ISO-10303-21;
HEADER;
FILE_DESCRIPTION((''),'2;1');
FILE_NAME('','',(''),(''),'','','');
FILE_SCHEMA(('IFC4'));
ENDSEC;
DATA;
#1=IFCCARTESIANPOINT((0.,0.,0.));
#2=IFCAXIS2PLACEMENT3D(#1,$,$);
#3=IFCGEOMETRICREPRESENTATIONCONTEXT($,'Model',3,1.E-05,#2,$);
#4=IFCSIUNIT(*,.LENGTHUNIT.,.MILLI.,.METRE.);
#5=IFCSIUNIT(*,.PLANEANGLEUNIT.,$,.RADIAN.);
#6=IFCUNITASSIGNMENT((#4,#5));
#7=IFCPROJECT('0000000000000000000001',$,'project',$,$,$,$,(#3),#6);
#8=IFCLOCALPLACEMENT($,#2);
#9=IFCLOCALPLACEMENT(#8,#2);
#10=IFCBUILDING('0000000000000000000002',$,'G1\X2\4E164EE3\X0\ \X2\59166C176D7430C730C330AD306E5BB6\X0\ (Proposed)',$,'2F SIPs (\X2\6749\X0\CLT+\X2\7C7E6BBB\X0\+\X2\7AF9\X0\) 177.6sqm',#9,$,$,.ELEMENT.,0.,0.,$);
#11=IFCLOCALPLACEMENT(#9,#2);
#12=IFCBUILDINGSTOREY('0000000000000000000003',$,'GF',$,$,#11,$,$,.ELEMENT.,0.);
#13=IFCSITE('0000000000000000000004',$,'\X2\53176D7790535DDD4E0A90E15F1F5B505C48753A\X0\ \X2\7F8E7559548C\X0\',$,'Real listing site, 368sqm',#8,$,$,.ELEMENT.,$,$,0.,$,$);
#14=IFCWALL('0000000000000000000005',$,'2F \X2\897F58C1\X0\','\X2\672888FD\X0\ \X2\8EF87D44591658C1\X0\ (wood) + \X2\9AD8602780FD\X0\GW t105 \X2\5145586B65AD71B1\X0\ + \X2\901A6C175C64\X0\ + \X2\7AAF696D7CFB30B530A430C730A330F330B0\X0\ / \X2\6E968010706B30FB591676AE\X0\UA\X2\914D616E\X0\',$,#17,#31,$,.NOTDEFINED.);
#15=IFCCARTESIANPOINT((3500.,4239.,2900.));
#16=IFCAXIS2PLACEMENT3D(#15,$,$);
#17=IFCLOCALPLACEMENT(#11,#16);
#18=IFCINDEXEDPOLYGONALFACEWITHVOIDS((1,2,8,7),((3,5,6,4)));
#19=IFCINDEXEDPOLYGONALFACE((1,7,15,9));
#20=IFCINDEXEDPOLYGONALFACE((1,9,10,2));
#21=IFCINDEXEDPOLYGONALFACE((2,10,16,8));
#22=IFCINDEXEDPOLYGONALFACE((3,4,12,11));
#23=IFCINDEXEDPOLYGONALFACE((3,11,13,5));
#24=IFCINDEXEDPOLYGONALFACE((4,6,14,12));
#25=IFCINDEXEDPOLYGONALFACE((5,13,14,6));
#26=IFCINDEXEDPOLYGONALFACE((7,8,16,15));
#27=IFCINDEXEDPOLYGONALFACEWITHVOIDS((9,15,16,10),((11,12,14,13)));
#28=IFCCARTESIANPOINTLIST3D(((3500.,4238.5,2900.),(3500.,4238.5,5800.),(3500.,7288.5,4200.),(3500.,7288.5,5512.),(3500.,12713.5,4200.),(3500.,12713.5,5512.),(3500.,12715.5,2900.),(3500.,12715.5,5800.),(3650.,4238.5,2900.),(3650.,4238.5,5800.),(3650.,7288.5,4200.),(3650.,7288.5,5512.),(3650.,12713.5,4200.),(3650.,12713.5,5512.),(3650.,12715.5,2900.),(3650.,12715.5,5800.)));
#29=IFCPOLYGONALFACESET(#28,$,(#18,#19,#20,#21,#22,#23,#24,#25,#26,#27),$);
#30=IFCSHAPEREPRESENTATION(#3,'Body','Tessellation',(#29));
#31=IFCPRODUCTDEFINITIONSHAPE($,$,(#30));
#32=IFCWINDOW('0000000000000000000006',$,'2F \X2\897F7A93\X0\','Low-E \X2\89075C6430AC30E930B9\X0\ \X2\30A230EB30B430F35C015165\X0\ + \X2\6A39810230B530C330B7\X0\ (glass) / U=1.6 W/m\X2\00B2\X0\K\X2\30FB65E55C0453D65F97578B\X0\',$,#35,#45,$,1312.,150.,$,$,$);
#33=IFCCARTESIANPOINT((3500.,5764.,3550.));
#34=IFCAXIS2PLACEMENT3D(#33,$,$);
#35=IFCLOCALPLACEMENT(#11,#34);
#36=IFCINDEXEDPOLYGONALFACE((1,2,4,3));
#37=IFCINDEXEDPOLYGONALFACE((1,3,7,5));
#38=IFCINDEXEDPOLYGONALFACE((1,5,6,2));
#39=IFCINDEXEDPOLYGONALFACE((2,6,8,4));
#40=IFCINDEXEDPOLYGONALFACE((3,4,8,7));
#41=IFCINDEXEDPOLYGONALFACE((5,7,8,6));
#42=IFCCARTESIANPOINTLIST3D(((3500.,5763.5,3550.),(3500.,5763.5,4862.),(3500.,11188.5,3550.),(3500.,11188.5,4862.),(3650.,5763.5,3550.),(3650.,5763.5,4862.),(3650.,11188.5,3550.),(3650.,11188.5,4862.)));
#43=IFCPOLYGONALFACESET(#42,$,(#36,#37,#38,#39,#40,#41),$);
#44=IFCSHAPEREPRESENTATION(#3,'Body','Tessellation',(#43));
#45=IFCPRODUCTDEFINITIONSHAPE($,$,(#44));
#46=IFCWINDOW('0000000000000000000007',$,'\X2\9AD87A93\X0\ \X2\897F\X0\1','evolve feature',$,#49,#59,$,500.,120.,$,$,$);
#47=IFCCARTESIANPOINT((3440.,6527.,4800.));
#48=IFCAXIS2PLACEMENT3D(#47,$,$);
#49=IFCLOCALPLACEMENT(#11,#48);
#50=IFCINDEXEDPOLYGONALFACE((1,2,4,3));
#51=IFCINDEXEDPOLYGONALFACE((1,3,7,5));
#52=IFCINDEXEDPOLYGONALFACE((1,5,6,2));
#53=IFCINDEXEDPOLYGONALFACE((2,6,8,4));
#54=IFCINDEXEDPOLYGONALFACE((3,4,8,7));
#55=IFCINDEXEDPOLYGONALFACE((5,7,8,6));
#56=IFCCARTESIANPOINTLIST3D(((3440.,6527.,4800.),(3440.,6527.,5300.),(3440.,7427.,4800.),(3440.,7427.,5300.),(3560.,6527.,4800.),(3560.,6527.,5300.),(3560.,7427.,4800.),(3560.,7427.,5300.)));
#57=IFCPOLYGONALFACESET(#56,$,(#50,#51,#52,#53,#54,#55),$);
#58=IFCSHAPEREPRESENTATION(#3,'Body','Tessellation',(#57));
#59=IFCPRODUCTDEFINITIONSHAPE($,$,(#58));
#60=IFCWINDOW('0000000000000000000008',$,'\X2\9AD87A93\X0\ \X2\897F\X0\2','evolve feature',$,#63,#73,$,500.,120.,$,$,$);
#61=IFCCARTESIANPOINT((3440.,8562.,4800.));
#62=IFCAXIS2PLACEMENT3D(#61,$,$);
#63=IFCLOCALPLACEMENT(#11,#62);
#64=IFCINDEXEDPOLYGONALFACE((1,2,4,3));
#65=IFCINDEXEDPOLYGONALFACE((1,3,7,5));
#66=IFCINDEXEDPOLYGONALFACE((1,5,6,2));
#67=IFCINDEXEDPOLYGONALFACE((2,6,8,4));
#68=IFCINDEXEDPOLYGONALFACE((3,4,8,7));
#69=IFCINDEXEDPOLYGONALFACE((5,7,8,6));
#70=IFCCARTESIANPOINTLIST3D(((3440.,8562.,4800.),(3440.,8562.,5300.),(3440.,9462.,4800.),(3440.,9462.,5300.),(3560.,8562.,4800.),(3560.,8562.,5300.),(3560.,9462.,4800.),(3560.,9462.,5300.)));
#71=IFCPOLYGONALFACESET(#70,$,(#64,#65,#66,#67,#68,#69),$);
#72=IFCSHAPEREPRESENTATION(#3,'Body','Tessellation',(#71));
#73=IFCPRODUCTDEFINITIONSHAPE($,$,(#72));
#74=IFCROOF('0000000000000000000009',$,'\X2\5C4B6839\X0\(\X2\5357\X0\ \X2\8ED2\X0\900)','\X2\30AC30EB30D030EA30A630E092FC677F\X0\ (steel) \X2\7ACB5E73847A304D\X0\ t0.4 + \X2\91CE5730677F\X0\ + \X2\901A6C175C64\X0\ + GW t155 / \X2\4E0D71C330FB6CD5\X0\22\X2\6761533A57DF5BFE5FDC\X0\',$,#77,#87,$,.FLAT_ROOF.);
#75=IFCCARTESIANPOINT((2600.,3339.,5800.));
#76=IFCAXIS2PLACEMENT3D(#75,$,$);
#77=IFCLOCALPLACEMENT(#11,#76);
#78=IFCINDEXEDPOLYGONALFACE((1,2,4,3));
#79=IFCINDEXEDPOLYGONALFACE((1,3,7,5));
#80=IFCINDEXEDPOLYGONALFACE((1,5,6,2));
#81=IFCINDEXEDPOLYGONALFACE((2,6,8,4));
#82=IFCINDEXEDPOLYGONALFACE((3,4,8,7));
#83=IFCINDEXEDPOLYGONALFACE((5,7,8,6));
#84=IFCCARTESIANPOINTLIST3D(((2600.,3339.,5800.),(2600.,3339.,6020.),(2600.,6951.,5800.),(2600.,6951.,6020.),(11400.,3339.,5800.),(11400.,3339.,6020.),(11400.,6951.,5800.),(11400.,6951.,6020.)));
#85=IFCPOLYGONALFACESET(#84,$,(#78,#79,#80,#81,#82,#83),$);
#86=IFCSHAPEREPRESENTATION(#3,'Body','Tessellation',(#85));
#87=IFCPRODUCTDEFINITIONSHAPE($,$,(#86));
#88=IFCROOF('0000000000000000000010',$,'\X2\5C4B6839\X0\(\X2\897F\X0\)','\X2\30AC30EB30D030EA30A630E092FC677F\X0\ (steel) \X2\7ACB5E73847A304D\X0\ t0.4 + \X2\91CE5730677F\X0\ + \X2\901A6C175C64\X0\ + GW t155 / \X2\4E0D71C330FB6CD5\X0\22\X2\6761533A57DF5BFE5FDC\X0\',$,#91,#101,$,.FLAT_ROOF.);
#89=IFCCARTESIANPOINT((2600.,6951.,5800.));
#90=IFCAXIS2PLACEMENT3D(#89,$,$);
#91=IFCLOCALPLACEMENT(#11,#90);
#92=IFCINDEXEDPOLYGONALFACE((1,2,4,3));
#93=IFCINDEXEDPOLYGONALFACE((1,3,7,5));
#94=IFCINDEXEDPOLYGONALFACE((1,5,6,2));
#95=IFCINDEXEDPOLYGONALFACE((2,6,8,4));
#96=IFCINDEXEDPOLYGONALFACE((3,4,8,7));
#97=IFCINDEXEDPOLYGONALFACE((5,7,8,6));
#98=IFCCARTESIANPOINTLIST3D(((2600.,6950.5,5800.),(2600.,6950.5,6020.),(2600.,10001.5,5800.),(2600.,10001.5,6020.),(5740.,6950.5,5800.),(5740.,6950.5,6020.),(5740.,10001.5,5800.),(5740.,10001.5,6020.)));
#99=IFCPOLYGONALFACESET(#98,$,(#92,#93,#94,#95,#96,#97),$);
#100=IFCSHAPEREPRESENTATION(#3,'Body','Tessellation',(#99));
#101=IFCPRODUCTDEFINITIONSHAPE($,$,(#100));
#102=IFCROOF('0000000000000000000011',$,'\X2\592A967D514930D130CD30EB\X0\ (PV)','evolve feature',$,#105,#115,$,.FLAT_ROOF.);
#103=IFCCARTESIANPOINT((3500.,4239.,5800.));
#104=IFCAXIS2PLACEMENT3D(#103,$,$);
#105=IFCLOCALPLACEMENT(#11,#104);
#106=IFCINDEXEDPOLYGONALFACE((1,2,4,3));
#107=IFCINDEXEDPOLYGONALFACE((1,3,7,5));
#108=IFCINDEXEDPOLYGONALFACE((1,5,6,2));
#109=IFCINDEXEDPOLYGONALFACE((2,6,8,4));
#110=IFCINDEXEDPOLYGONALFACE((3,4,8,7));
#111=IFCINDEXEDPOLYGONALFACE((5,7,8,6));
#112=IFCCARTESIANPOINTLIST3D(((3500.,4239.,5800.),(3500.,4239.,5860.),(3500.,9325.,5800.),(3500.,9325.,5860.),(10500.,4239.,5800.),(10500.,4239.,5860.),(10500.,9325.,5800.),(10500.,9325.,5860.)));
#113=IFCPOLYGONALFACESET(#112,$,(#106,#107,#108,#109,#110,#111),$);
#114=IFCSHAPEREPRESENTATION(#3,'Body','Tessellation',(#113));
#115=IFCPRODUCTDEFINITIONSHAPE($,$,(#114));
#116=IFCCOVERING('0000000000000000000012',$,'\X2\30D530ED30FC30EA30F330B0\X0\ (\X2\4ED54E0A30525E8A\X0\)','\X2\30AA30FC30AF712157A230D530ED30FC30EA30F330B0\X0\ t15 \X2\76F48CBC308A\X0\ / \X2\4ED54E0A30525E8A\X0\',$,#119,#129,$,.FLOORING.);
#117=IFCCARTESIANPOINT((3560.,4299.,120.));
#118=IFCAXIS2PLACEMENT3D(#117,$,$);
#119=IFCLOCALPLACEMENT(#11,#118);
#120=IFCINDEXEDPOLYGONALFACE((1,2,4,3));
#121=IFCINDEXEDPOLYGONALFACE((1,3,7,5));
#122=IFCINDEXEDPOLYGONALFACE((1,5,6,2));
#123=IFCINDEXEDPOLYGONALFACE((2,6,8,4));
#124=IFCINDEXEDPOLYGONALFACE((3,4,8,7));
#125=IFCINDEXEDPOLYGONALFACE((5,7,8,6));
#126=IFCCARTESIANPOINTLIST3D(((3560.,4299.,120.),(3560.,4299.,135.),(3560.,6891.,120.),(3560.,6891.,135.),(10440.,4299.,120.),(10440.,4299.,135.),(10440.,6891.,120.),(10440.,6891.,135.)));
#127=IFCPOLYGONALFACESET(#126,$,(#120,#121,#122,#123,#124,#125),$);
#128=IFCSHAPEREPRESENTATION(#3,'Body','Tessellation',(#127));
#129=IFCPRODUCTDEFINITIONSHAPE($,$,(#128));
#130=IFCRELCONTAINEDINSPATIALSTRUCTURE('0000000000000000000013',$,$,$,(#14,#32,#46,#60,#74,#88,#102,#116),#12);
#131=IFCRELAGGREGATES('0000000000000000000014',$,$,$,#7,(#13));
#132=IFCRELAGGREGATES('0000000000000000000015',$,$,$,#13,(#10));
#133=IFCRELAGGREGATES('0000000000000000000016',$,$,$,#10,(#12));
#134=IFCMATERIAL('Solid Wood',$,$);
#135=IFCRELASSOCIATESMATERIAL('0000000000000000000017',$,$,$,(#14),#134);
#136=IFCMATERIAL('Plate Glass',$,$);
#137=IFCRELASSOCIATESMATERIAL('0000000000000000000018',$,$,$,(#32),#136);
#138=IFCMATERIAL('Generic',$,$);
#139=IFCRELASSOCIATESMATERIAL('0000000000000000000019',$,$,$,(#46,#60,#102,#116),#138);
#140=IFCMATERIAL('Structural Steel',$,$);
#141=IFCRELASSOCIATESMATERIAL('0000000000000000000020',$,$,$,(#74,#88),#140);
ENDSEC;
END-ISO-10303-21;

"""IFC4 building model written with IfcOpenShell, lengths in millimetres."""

from ifc_helpers import new_model, si_unit, frame, frame_2d, origin, place, context, project, spatial, rectangle, extrude, material, element, fill, save


model = new_model("IFC4")

# Units and contexts
model_context = context("Model", 3, precision=1e-05, world=origin())
ifc_project = project(units=[si_unit("LENGTHUNIT", "METRE", prefix="MILLI"), si_unit("PLANEANGLEUNIT", "RADIAN")], contexts=[model_context])

# Site, building, storey
site_placement = place(None, origin())
site = spatial("IfcSite", under=ifc_project, at=site_placement, Name="北海道川上郡弟子屈町 美留和", ObjectType="Real listing site, 368sqm", CompositionType="ELEMENT", RefElevation=0.0)
building_placement = place(site_placement, origin())
building = spatial("IfcBuilding", under=site, at=building_placement, Name="G1世代 外気浴デッキの家 (Proposed)", ObjectType="2F SIPs (杉CLT+籾殻+竹) 177.6sqm", CompositionType="ELEMENT", ElevationOfRefHeight=0.0, ElevationOfTerrain=0.0)
storey_placement = place(building_placement, origin())
storey = spatial("IfcBuildingStorey", under=building, at=storey_placement, Name="GF", CompositionType="ELEMENT", Elevation=0.0)

# Shared definitions
ifc_material_1 = material(Name="Solid Wood")
ifc_material_2 = material(Name="Generic")

# Shared definitions
ifc_material_3 = material(Name="Plate Glass")

# Wall, openings, windows
wall_1_placement = place(storey_placement, frame((3500.0, 4239.0, 2900.0)))
wall_1 = element("IfcWall", 1, at=wall_1_placement, inside=storey, material=ifc_material_1, Name="2F 西壁", Description="木製 軸組外壁 (wood) + 高性能GW t105 充填断熱 + 通気層 + 窯業系サイディング / 準耐火・外皮UA配慮", PredefinedType="NOTDEFINED", context=model_context, shape_type="SweptSolid", body=[
    extrude(rectangle(XDim=150.0, YDim=8477.0, at=frame_2d((75.0, 4238.0))), frame((3500.0, 4239.0, 2900.0)), (0.0, 0.0, 1.0), 2900.0),
])
opening_1_placement = place(storey_placement, frame((3500.0, 5764.0, 3550.0)))
opening_1 = element("IfcOpeningElement", 2, at=opening_1_placement, cuts=wall_1, PredefinedType="NOTDEFINED", context=model_context, shape_type="SweptSolid", body=[
    extrude(rectangle(XDim=150.0, YDim=5425.0, at=frame_2d((75.0, 2712.0))), frame((3500.0, 5764.0, 3550.0)), (0.0, 0.0, 1.0), 1312.0),
])
opening_2_placement = place(storey_placement, frame((3440.0, 6527.0, 4800.0)))
opening_2 = element("IfcOpeningElement", 3, at=opening_2_placement, cuts=wall_1, PredefinedType="NOTDEFINED", context=model_context, shape_type="SweptSolid", body=[
    extrude(rectangle(XDim=120.0, YDim=900.0, at=frame_2d((60.0, 450.0))), frame((3440.0, 6527.0, 4800.0)), (0.0, 0.0, 1.0), 500.0),
])
opening_3_placement = place(storey_placement, frame((3440.0, 8562.0, 4800.0)))
opening_3 = element("IfcOpeningElement", 4, at=opening_3_placement, cuts=wall_1, PredefinedType="NOTDEFINED", context=model_context, shape_type="SweptSolid", body=[
    extrude(rectangle(XDim=120.0, YDim=900.0, at=frame_2d((60.0, 450.0))), frame((3440.0, 8562.0, 4800.0)), (0.0, 0.0, 1.0), 500.0),
])
window_1_placement = place(storey_placement, frame((3500.0, 5764.0, 3550.0)))
window_1 = element("IfcWindow", 5, at=window_1_placement, inside=storey, material=ifc_material_3, Name="2F 西窓", Description="Low-E 複層ガラス アルゴン封入 + 樹脂サッシ (glass) / U=1.6 W/m²K・日射取得型", OverallHeight=1312.0, OverallWidth=150.0, context=model_context, shape_type="SweptSolid", body=[
    extrude(rectangle(XDim=150.0, YDim=5425.0, at=frame_2d((75.0, 2712.0))), frame((3500.0, 5764.0, 3550.0)), (0.0, 0.0, 1.0), 1312.0),
])
fill(opening_1, window_1)
window_2_placement = place(storey_placement, frame((3440.0, 6527.0, 4800.0)))
window_2 = element("IfcWindow", 6, at=window_2_placement, inside=storey, material=ifc_material_2, Name="高窓 西1", Description="evolve feature", OverallHeight=500.0, OverallWidth=120.0, context=model_context, shape_type="SweptSolid", body=[
    extrude(rectangle(XDim=120.0, YDim=900.0, at=frame_2d((60.0, 450.0))), frame((3440.0, 6527.0, 4800.0)), (0.0, 0.0, 1.0), 500.0),
])
fill(opening_2, window_2)
window_3_placement = place(storey_placement, frame((3440.0, 8562.0, 4800.0)))
window_3 = element("IfcWindow", 7, at=window_3_placement, inside=storey, material=ifc_material_2, Name="高窓 西2", Description="evolve feature", OverallHeight=500.0, OverallWidth=120.0, context=model_context, shape_type="SweptSolid", body=[
    extrude(rectangle(XDim=120.0, YDim=900.0, at=frame_2d((60.0, 450.0))), frame((3440.0, 8562.0, 4800.0)), (0.0, 0.0, 1.0), 500.0),
])
fill(opening_3, window_3)

# Roofs
ifc_material_4 = material(Name="Structural Steel")
roof_1_placement = place(storey_placement, frame((2600.0, 3339.0, 5800.0)))
element("IfcRoof", 8, at=roof_1_placement, inside=storey, material=ifc_material_4, Name="屋根(南 軒900)", Description="ガルバリウム鋼板 (steel) 立平葺き t0.4 + 野地板 + 通気層 + GW t155 / 不燃・法22条区域対応", PredefinedType="FLAT_ROOF", context=model_context, shape_type="SweptSolid", body=[
    extrude(rectangle(XDim=8800.0, YDim=3612.0, at=frame_2d((4400.0, 1806.0))), frame((2600.0, 3339.0, 5800.0)), (0.0, 0.0, 1.0), 220.0),
])
roof_2_placement = place(storey_placement, frame((2600.0, 6951.0, 5800.0)))
element("IfcRoof", 9, at=roof_2_placement, inside=storey, material=ifc_material_4, Name="屋根(西)", Description="ガルバリウム鋼板 (steel) 立平葺き t0.4 + 野地板 + 通気層 + GW t155 / 不燃・法22条区域対応", PredefinedType="FLAT_ROOF", context=model_context, shape_type="SweptSolid", body=[
    extrude(rectangle(XDim=3140.0, YDim=3051.0, at=frame_2d((1570.0, 1525.0))), frame((2600.0, 6951.0, 5800.0)), (0.0, 0.0, 1.0), 220.0),
])
roof_3_placement = place(storey_placement, frame((3500.0, 4239.0, 5800.0)))
element("IfcRoof", 10, at=roof_3_placement, inside=storey, material=ifc_material_2, Name="太陽光パネル (PV)", Description="evolve feature", PredefinedType="FLAT_ROOF", context=model_context, shape_type="SweptSolid", body=[
    extrude(rectangle(XDim=7000.0, YDim=5086.0, at=frame_2d((3500.0, 2543.0))), frame((3500.0, 4239.0, 5800.0)), (0.0, 0.0, 1.0), 60.0),
])

# Covering
covering_placement = place(storey_placement, frame((3560.0, 4299.0, 120.0)))
element("IfcCovering", 11, at=covering_placement, inside=storey, material=ifc_material_2, Name="フローリング (仕上げ床)", Description="オーク無垢フローリング t15 直貼り / 仕上げ床", PredefinedType="FLOORING", context=model_context, shape_type="SweptSolid", body=[
    extrude(rectangle(XDim=6880.0, YDim=2592.0, at=frame_2d((3440.0, 1296.0))), frame((3560.0, 4299.0, 120.0)), (0.0, 0.0, 1.0), 15.0),
])

save(model, "model.ifc")
